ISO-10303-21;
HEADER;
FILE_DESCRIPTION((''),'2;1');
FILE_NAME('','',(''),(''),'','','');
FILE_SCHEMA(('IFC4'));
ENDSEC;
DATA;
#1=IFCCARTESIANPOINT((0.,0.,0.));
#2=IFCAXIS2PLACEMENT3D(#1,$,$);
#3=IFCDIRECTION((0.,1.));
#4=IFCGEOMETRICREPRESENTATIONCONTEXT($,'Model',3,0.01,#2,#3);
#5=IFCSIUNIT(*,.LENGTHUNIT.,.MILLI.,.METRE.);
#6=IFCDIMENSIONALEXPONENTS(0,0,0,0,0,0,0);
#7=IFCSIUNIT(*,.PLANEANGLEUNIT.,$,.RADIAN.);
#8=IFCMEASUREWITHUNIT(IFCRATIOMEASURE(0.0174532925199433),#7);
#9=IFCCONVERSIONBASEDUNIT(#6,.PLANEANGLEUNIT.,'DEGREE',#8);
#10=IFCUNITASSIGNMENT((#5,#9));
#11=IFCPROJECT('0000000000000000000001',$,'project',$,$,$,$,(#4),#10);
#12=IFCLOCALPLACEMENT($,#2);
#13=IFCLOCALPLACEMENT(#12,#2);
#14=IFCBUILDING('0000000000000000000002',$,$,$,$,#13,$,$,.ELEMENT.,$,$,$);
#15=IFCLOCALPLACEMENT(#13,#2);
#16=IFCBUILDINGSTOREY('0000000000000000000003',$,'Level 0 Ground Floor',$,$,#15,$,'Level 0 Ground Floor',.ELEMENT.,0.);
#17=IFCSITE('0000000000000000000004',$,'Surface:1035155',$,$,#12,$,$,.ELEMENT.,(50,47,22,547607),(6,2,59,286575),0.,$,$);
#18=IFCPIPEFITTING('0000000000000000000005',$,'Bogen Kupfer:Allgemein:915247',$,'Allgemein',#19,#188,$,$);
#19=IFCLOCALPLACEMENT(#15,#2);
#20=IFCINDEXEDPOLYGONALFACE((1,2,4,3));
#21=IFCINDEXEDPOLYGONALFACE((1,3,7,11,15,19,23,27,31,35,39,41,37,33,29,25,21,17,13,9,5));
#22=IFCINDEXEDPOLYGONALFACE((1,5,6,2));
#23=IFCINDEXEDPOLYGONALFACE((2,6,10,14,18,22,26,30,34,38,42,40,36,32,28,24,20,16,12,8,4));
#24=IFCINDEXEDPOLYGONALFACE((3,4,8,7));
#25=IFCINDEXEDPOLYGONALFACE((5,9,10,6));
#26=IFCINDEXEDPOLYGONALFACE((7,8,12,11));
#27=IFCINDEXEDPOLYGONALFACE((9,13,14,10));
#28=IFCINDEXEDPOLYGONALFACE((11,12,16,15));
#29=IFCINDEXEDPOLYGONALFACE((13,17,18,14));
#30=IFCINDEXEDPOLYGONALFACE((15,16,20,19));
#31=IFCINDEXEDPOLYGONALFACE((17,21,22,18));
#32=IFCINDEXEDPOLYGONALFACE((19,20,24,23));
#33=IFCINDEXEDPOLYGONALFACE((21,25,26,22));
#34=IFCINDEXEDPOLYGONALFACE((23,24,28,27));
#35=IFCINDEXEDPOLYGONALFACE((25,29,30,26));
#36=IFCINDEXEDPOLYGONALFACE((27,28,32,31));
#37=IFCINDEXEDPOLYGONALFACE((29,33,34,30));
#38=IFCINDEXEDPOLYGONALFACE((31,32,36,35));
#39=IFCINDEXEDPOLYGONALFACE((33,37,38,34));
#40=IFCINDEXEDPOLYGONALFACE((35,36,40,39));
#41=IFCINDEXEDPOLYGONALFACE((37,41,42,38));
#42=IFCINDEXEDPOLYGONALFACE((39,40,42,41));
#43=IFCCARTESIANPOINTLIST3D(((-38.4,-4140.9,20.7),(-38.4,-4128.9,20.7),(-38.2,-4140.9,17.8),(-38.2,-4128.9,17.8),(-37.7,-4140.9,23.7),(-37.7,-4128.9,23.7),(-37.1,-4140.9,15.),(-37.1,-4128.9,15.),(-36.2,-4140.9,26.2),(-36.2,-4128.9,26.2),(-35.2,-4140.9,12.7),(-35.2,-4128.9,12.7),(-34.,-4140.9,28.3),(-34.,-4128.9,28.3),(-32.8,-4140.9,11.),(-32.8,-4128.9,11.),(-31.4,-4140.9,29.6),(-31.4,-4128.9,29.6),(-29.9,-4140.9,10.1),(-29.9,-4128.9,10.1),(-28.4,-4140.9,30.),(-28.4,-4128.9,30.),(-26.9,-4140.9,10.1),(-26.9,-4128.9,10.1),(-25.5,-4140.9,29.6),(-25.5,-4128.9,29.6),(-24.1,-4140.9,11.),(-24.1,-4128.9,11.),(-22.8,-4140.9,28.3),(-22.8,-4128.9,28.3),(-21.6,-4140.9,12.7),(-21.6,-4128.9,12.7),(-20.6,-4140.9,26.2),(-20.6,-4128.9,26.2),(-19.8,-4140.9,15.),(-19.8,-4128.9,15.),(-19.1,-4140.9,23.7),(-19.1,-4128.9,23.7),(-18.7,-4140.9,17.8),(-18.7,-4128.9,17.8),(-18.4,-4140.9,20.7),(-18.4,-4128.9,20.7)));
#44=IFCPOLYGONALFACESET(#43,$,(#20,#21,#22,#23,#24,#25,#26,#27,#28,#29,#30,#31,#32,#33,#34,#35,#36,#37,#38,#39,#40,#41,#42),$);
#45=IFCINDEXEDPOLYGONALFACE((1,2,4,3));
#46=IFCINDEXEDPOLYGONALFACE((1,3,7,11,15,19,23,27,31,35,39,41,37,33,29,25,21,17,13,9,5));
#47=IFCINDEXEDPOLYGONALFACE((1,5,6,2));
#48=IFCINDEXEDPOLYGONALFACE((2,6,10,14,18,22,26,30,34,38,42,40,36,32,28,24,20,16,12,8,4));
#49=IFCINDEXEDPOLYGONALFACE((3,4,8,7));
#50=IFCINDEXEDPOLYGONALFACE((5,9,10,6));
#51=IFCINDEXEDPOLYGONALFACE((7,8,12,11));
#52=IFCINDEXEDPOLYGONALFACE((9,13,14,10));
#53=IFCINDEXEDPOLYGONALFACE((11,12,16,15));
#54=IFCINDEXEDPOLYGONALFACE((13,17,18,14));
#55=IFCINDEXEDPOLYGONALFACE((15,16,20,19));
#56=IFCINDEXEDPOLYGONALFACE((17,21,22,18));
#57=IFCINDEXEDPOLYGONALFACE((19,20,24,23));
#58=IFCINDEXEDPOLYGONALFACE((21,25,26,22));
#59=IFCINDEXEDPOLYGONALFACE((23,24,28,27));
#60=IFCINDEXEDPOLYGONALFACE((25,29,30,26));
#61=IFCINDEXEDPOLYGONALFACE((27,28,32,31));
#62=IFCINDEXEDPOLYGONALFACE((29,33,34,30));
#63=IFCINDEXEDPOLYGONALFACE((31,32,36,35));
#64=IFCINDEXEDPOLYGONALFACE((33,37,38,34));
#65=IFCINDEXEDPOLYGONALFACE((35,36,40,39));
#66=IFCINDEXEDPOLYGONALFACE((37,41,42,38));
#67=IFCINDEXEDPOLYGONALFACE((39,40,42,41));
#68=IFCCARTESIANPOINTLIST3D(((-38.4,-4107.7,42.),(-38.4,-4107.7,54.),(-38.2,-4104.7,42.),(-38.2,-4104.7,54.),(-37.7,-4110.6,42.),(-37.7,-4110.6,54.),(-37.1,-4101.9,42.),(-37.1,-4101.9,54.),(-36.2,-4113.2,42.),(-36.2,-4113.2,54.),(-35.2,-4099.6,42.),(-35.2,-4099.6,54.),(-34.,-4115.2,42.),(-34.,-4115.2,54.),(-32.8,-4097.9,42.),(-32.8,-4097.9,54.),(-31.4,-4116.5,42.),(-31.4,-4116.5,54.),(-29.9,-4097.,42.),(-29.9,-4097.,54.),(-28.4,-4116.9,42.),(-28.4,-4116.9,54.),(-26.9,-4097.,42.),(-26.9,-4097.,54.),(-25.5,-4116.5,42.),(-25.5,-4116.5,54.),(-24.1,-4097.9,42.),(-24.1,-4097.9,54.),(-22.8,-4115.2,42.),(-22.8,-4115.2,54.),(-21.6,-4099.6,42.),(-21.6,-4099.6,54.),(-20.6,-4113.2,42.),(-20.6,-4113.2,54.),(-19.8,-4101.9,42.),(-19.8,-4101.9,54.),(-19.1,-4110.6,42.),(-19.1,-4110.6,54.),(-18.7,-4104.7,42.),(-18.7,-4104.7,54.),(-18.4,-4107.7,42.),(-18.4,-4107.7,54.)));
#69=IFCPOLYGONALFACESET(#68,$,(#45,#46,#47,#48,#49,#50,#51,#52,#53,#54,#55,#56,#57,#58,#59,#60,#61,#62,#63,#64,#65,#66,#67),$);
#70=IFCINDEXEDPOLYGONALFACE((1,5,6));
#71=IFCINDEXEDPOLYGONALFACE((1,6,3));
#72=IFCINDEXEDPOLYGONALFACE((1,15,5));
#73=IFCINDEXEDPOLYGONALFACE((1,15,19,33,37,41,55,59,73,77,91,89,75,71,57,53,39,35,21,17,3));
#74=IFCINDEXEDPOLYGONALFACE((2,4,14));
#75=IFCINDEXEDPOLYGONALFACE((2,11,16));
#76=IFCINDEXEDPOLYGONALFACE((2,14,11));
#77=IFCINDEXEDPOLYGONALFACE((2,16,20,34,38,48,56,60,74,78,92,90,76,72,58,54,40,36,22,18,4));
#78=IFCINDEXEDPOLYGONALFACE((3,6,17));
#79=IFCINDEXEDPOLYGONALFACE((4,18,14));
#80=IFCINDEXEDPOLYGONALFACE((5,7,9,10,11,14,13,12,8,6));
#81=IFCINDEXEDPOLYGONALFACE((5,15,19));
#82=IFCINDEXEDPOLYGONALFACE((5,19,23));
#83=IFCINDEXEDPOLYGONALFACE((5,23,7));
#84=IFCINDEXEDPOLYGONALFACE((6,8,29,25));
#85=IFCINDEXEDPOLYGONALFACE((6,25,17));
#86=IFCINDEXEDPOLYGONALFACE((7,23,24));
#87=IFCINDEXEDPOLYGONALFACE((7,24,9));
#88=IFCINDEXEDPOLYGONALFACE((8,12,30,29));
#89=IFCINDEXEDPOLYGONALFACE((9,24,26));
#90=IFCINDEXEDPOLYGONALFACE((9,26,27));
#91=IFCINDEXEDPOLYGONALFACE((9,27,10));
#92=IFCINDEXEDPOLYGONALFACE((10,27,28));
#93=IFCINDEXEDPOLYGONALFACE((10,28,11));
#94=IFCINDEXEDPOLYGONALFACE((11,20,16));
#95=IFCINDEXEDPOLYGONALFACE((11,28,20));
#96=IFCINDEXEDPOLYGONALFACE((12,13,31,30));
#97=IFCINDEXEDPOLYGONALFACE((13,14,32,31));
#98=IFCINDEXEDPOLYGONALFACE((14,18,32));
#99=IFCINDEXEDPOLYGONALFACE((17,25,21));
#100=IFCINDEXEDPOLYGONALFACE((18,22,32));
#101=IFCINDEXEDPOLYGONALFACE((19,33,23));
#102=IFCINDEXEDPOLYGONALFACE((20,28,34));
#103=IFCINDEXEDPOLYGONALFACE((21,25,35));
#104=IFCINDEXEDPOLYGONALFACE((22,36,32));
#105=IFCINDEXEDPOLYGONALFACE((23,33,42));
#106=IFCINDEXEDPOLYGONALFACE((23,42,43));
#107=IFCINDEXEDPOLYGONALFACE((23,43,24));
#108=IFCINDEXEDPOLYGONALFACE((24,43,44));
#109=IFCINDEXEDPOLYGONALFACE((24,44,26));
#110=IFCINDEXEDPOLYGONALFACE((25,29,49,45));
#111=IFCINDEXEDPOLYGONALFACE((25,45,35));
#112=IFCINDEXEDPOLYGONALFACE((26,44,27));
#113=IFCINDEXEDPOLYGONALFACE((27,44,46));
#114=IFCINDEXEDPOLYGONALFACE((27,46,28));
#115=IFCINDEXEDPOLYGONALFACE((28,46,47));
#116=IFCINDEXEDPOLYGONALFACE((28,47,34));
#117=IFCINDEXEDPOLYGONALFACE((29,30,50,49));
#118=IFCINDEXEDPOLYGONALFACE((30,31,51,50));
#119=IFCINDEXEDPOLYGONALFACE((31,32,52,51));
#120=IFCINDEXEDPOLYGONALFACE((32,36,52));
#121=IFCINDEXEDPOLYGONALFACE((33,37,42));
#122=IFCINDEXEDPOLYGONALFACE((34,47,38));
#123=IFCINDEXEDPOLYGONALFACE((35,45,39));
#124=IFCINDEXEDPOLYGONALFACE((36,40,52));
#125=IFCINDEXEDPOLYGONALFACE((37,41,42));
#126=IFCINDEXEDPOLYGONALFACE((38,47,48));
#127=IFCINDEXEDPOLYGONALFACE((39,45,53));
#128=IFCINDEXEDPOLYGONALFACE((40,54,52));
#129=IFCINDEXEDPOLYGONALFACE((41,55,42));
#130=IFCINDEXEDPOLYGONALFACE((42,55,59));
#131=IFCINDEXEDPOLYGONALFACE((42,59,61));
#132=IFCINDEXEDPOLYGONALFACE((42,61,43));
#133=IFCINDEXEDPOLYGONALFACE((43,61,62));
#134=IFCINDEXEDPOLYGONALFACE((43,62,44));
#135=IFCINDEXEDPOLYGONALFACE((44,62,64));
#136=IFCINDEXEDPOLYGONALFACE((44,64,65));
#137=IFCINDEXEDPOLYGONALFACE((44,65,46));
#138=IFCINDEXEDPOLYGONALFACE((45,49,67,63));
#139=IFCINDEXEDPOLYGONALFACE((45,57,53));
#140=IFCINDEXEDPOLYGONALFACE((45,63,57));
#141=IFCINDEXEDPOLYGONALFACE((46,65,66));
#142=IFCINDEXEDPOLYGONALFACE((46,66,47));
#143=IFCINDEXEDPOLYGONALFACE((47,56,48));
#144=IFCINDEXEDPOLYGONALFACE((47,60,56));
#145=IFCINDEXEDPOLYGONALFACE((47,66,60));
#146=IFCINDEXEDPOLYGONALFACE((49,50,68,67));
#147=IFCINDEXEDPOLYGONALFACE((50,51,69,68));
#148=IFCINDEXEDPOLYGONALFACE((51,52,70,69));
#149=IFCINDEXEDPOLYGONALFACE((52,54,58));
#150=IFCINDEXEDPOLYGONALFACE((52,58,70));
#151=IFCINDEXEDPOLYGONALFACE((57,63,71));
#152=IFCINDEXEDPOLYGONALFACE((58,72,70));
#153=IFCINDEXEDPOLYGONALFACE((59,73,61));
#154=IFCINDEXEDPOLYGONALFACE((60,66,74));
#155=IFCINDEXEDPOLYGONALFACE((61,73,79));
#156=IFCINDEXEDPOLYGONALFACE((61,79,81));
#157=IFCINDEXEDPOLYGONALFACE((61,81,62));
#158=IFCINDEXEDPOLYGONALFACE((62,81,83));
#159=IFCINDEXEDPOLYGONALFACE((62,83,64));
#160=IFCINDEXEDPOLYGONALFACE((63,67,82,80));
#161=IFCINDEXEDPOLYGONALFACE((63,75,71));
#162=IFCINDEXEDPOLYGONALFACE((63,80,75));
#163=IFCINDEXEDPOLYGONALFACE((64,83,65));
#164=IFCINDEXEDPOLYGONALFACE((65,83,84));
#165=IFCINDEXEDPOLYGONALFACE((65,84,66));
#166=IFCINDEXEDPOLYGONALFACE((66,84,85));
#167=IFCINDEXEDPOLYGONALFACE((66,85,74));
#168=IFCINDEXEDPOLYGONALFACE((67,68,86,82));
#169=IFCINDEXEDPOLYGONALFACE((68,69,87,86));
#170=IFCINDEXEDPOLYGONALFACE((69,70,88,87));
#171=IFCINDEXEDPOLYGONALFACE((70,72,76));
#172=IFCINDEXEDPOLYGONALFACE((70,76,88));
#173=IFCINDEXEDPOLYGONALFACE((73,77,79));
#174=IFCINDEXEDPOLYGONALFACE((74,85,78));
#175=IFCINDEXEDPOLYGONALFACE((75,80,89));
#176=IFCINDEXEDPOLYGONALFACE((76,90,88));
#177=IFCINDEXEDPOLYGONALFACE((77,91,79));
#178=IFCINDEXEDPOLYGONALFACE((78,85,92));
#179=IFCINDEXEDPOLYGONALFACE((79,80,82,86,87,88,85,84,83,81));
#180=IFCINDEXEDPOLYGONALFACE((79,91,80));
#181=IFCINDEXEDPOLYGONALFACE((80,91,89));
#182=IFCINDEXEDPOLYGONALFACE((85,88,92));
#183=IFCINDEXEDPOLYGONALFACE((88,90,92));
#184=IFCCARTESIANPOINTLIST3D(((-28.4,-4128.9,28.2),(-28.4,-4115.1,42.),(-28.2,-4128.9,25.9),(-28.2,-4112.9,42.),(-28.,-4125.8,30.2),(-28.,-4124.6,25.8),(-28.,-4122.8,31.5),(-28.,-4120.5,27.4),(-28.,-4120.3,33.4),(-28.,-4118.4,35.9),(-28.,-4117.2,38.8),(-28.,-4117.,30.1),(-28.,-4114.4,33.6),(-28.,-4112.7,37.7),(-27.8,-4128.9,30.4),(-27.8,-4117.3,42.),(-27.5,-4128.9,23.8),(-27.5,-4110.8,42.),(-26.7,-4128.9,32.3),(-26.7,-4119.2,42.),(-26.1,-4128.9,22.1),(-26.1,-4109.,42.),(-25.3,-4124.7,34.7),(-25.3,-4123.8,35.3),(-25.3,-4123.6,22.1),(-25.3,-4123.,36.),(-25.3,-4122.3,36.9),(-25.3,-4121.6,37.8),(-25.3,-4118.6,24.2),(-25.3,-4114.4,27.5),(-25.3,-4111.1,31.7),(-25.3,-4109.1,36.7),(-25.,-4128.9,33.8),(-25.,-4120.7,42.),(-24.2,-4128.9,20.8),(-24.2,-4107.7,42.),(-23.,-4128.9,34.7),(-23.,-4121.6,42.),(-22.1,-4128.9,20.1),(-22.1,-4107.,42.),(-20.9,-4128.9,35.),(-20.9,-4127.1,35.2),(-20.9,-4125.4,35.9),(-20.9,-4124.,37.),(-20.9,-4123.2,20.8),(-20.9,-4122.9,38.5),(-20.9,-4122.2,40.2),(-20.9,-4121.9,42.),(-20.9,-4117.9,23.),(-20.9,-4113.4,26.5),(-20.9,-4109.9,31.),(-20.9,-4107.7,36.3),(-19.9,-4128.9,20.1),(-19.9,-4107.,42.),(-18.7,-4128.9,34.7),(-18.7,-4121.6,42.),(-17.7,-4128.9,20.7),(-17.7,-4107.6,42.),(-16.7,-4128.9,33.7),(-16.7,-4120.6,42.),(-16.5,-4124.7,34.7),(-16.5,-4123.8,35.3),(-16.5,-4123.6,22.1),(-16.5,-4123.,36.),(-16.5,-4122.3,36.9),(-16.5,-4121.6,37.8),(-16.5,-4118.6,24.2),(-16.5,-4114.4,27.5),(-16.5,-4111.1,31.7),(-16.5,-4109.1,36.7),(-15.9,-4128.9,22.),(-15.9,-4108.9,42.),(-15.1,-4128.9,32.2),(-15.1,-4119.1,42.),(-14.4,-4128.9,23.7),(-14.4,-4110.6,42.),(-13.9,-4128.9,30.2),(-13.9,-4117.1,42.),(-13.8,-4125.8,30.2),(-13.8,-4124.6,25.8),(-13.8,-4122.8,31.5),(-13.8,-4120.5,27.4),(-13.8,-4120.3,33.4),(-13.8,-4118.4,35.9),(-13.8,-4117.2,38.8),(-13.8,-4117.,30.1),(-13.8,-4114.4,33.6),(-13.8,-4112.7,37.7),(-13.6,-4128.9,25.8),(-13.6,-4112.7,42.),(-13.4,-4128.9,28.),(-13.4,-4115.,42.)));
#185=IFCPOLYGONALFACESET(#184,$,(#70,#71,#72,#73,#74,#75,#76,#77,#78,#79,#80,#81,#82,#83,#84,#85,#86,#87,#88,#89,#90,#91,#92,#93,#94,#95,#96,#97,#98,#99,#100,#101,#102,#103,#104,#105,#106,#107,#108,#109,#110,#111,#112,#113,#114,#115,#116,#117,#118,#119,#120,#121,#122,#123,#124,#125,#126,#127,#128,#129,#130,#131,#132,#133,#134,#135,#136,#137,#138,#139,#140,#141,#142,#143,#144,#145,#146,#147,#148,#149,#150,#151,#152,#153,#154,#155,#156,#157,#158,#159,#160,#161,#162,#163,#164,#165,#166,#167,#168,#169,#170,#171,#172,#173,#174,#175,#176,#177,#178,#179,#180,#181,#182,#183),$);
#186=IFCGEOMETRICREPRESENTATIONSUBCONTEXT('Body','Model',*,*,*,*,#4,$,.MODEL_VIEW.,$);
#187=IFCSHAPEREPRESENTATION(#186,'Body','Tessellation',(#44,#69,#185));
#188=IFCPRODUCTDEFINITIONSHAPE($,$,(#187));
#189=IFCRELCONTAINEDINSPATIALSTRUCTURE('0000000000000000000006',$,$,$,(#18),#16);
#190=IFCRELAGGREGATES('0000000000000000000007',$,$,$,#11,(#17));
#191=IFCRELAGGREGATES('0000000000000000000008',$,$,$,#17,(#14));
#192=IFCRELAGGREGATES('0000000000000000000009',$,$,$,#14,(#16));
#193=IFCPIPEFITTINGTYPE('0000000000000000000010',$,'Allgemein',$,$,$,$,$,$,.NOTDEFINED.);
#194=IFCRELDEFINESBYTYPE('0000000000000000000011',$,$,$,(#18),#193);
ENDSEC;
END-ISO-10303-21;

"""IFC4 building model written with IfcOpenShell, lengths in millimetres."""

from ifc_helpers import new_model, entity, si_unit, converted_unit, direction, frame, frame_2d, origin, place, context, subcontext, project, spatial, circle, extrude, source, transform, mapped, type_object, type_shapes, element, save


model = new_model("IFC4")

# Units and contexts
model_context = context("Model", 3, precision=0.01, world=origin(), true_north=direction((0.0, 1.0)))
body_context = subcontext(model_context, "Body", "Model", "MODEL_VIEW")
ifc_project = project(units=[si_unit("LENGTHUNIT", "METRE", prefix="MILLI"), converted_unit("PLANEANGLEUNIT", "DEGREE", entity("IfcRatioMeasure", 0.0174532925199433), si_unit("PLANEANGLEUNIT", "RADIAN"), dimensions=[0, 0, 0, 0, 0, 0, 0])], contexts=[model_context])

# Site, building, storey
site_placement = place(None, origin())
site = spatial("IfcSite", under=ifc_project, at=site_placement, Name="Surface:1035155", CompositionType="ELEMENT", RefLatitude=(50, 47, 22, 547607), RefLongitude=(6, 2, 59, 286575), RefElevation=0.0)
building_placement = place(site_placement, origin())
building = spatial("IfcBuilding", under=site, at=building_placement, CompositionType="ELEMENT")
storey_placement = place(building_placement, origin())
storey = spatial("IfcBuildingStorey", under=building, at=storey_placement, Name="Level 0 Ground Floor", LongName="Level 0 Ground Floor", CompositionType="ELEMENT", Elevation=0.0)

# Shared definitions
pipe_fitting_type = type_object("IfcPipeFittingType", Name="Allgemein", PredefinedType="NOTDEFINED")
ifc_direction = entity("IfcDirection", [0.0, 0.0, -1.0])
trimmed_curve = entity("IfcTrimmedCurve", entity("IfcCircle", entity("IfcAxis2Placement2D", entity("IfcCartesianPoint", [-14.5, 0.0]), entity("IfcDirection", [0.0, 1.0])), 14.5), [entity("IfcParameterValue", 270.0)], [entity("IfcParameterValue", 0.0)], True, "PARAMETER")
shared_shape_1 = source(origin(), body_context, "Body", "SolidModel", [
    extrude(circle(Radius=10.0, at=frame_2d((0.0, 0.0), x_axis=(1.0, 0.0))), frame((0.0, 22.0, 0.0), z_axis=(0.0, 1.0, 0.0), x_axis=(-1.0, 0.0, 0.0)), (0.0, 0.0, 1.0), 12.0),
    extrude(circle(Radius=10.0, at=frame_2d((0.0, 0.0), x_axis=(1.0, 0.0))), frame((-34.0, 0.0, 0.0), z_axis=(1.0, 0.0, 0.0), x_axis=(0.0, 1.0, 0.0)), (0.0, 0.0, 1.0), 12.0),
    entity("IfcSurfaceCurveSweptAreaSolid", entity("IfcCircleProfileDef", "AREA", None, entity("IfcAxis2Placement2D", entity("IfcCartesianPoint", [0.0, 7.5]), entity("IfcDirection", [1.0, 0.0])), 7.5), entity("IfcAxis2Placement3D", entity("IfcCartesianPoint", [-7.5, 22.0, 0.0]), ifc_direction, entity("IfcDirection", [1.0, 0.0, 0.0])), trimmed_curve, 0.0, 90.0, entity("IfcSurfaceOfLinearExtrusion", entity("IfcArbitraryOpenProfileDef", "CURVE", None, trimmed_curve), entity("IfcAxis2Placement3D", entity("IfcCartesianPoint", [0.0, 0.0, -304.8])), ifc_direction, 1.0)),
])
type_shapes(pipe_fitting_type, [shared_shape_1])

# Pipe fitting
for number, where, z_axis, x_axis, name in (
    (1, (-28.4, -4106.9, 20.0), (-1.0, 0.0, 0.0), (0.0, 0.0, -1.0), "Bogen Kupfer:Allgemein:915247"),
):
    element("IfcPipeFitting", number, at=place(storey_placement, frame(where, z_axis=z_axis, x_axis=x_axis)), inside=storey, type_object=pipe_fitting_type, Name=name, ObjectType="Allgemein", context=body_context, shape_type="MappedRepresentation", body=[
        mapped(shared_shape_1, transform((0.0, 0.0, 0.0), scale=1.0)),
    ])

save(model, "model.ifc")
